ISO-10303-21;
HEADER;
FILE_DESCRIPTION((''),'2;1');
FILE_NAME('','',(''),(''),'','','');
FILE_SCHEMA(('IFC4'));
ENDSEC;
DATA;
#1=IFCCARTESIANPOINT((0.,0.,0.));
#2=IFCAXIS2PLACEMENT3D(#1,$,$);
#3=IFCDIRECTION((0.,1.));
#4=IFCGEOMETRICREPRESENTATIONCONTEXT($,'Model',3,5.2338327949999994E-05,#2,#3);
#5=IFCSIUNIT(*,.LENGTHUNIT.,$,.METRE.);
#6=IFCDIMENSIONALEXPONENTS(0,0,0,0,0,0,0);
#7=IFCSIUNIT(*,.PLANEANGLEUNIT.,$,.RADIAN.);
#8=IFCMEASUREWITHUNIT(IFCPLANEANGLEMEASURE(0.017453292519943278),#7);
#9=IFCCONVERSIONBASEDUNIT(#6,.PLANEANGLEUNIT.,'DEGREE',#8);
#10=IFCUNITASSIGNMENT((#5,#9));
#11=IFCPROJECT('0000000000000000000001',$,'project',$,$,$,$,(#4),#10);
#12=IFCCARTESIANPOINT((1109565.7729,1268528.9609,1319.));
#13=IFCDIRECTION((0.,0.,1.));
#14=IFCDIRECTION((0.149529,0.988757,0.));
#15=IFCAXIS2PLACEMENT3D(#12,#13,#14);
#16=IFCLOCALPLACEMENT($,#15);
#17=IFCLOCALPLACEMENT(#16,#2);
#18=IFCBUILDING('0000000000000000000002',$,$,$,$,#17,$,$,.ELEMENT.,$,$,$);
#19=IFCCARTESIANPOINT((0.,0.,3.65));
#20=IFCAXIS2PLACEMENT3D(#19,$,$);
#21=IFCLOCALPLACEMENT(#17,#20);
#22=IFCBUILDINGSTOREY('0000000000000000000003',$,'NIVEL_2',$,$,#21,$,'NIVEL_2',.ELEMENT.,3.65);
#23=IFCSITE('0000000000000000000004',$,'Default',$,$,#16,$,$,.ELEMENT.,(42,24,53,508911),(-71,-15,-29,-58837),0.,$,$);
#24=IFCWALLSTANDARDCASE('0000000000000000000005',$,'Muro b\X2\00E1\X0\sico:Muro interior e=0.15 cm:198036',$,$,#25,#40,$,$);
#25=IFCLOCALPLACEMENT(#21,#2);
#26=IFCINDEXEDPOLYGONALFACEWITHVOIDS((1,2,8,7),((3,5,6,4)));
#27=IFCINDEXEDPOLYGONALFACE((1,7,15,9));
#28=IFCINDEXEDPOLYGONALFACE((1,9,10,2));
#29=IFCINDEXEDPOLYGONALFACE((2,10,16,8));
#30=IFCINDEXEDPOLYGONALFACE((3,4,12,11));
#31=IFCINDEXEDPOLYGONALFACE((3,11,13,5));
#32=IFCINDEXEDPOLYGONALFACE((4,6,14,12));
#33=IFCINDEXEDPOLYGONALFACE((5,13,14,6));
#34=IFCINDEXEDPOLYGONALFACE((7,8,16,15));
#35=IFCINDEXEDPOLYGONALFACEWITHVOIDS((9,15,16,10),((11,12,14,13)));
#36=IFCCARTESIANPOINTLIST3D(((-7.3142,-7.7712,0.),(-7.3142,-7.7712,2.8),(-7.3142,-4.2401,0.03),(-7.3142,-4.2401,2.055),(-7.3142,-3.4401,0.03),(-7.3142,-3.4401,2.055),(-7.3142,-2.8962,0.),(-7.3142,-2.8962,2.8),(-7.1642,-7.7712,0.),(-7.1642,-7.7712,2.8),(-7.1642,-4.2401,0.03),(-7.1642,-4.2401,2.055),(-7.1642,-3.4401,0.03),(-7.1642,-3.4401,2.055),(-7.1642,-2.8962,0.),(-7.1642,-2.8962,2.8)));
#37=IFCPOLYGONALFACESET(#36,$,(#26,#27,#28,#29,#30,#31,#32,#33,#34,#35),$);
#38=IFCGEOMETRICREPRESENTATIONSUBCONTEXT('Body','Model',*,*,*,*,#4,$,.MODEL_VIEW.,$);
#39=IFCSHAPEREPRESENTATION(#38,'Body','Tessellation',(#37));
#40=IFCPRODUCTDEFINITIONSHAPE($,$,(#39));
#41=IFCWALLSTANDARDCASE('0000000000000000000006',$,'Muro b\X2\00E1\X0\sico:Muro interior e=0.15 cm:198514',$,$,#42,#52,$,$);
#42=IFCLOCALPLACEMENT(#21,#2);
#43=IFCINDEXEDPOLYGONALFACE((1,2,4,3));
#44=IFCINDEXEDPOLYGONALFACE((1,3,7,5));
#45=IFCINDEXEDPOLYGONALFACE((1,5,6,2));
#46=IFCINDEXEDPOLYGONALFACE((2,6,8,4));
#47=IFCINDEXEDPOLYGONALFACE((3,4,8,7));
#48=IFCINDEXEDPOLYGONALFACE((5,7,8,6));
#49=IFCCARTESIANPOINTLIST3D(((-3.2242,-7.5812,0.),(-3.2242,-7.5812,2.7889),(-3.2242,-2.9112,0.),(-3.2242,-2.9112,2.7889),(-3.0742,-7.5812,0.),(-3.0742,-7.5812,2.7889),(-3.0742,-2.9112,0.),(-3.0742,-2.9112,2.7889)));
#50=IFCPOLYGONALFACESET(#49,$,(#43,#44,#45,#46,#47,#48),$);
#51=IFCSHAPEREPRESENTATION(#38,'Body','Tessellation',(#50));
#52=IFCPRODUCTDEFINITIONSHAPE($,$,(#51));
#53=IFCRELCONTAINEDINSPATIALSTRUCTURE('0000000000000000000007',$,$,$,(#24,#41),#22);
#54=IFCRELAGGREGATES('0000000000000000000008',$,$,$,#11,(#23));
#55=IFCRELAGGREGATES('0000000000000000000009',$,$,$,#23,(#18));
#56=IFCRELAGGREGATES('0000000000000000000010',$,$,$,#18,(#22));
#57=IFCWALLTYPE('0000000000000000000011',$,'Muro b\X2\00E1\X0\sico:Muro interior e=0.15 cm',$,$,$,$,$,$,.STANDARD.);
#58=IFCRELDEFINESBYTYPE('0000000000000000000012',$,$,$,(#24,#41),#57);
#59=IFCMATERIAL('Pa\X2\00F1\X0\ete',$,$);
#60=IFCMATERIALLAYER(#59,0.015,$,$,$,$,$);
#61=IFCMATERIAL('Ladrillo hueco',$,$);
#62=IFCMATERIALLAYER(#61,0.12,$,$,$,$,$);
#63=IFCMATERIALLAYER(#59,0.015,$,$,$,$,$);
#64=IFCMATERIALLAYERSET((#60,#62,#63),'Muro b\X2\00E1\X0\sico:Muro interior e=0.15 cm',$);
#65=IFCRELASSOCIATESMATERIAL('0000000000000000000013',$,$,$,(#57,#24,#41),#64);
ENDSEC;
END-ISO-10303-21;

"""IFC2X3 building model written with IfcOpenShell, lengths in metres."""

from ifc_helpers import new_model, entity, si_unit, converted_unit, direction, frame, frame_2d, origin, place, context, subcontext, project, spatial, rectangle, extrude, material, layer, layer_set, layer_usage, type_object, element, save


model = new_model("IFC2X3")

# Units and contexts
model_context = context("Model", 3, precision=5.2338327949999994e-05, world=origin(), true_north=direction((0.0, 1.0)))
body_context = subcontext(model_context, "Body", "Model", "MODEL_VIEW")
ifc_project = project(units=[si_unit("LENGTHUNIT", "METRE"), converted_unit("PLANEANGLEUNIT", "DEGREE", entity("IfcPlaneAngleMeasure", 0.017453292519943278), si_unit("PLANEANGLEUNIT", "RADIAN"), dimensions=[0, 0, 0, 0, 0, 0, 0])], contexts=[model_context])

# Site, building, storey
site_placement = place(None, frame((1109565.7729, 1268528.9609, 1319.0), z_axis=(0.0, 0.0, 1.0), x_axis=(0.149529, 0.988757, 0.0)))
site = spatial("IfcSite", under=ifc_project, at=site_placement, Name="Default", CompositionType="ELEMENT", RefLatitude=(42, 24, 53, 508911), RefLongitude=(-71, -15, -29, -58837), RefElevation=0.0)
building_placement = place(site_placement, origin())
building = spatial("IfcBuilding", under=site, at=building_placement, CompositionType="ELEMENT")
storey_placement = place(building_placement, frame((0.0, 0.0, 3.65)))
storey = spatial("IfcBuildingStorey", under=building, at=storey_placement, Name="NIVEL_2", LongName="NIVEL_2", CompositionType="ELEMENT", Elevation=3.65)

# Wall, opening
ifc_material_1 = material(Name="Pañete")
ifc_layer_1 = layer(ifc_material_1, 0.015)
ifc_material_2 = material(Name="Ladrillo hueco")
ifc_layer_2 = layer(ifc_material_2, 0.12)
ifc_layer_3 = layer(ifc_material_1, 0.015)
ifc_layer_set_1 = layer_set([ifc_layer_1, ifc_layer_2, ifc_layer_3], Name="Muro básico:Muro interior e=0.15 cm")
ifc_layer_usage_1 = layer_usage(ifc_layer_set_1, "AXIS2", "NEGATIVE", 0.075)
wall_type_1 = type_object("IfcWallType", Name="Muro básico:Muro interior e=0.15 cm", PredefinedType="STANDARD", material=ifc_layer_set_1)
wall_1_placement = place(storey_placement, frame((-7.2392, -7.7712, 0.0), z_axis=(0.0, 0.0, 1.0), x_axis=(0.0, 1.0, 0.0)))
wall_1 = element("IfcWallStandardCase", 1, at=wall_1_placement, inside=storey, type_object=wall_type_1, material=ifc_layer_usage_1, Name="Muro básico:Muro interior e=0.15 cm:198036", context=body_context, shape_type="SweptSolid", body=[
    extrude(rectangle(XDim=4.875, YDim=0.15, at=frame_2d((2.4375, 0.0), x_axis=(-1.0, 0.0))), origin(), (0.0, 0.0, 1.0), 2.8),
])
opening_1_placement = place(wall_1_placement, frame((3.5311, -0.075, 0.03)))
element("IfcOpeningElement", 2, at=opening_1_placement, cuts=wall_1, ObjectType="Opening", context=body_context, shape_type="SweptSolid", body=[
    extrude(rectangle(XDim=2.025, YDim=0.8, at=frame_2d((1.0125, 0.4), x_axis=(1.0, 0.0))), frame((0.0, 0.0, 0.0), z_axis=(0.0, 1.0, 0.0), x_axis=(0.0, 0.0, 1.0)), (0.0, 0.0, 1.0), 0.15),
])

# Wall
ifc_layer_usage_2 = layer_usage(ifc_layer_set_1, "AXIS2", "NEGATIVE", 0.075)
wall_2_placement = place(storey_placement, frame((-3.1492, -7.5812, 0.0), z_axis=(0.0, 0.0, 1.0), x_axis=(0.0, 1.0, 0.0)))
element("IfcWallStandardCase", 3, at=wall_2_placement, inside=storey, type_object=wall_type_1, material=ifc_layer_usage_2, Name="Muro básico:Muro interior e=0.15 cm:198514", context=body_context, shape_type="SweptSolid", body=[
    extrude(rectangle(XDim=4.67, YDim=0.15, at=frame_2d((2.335, 0.0), x_axis=(-1.0, 0.0))), origin(), (0.0, 0.0, 1.0), 2.7889),
])

save(model, "model.ifc")
